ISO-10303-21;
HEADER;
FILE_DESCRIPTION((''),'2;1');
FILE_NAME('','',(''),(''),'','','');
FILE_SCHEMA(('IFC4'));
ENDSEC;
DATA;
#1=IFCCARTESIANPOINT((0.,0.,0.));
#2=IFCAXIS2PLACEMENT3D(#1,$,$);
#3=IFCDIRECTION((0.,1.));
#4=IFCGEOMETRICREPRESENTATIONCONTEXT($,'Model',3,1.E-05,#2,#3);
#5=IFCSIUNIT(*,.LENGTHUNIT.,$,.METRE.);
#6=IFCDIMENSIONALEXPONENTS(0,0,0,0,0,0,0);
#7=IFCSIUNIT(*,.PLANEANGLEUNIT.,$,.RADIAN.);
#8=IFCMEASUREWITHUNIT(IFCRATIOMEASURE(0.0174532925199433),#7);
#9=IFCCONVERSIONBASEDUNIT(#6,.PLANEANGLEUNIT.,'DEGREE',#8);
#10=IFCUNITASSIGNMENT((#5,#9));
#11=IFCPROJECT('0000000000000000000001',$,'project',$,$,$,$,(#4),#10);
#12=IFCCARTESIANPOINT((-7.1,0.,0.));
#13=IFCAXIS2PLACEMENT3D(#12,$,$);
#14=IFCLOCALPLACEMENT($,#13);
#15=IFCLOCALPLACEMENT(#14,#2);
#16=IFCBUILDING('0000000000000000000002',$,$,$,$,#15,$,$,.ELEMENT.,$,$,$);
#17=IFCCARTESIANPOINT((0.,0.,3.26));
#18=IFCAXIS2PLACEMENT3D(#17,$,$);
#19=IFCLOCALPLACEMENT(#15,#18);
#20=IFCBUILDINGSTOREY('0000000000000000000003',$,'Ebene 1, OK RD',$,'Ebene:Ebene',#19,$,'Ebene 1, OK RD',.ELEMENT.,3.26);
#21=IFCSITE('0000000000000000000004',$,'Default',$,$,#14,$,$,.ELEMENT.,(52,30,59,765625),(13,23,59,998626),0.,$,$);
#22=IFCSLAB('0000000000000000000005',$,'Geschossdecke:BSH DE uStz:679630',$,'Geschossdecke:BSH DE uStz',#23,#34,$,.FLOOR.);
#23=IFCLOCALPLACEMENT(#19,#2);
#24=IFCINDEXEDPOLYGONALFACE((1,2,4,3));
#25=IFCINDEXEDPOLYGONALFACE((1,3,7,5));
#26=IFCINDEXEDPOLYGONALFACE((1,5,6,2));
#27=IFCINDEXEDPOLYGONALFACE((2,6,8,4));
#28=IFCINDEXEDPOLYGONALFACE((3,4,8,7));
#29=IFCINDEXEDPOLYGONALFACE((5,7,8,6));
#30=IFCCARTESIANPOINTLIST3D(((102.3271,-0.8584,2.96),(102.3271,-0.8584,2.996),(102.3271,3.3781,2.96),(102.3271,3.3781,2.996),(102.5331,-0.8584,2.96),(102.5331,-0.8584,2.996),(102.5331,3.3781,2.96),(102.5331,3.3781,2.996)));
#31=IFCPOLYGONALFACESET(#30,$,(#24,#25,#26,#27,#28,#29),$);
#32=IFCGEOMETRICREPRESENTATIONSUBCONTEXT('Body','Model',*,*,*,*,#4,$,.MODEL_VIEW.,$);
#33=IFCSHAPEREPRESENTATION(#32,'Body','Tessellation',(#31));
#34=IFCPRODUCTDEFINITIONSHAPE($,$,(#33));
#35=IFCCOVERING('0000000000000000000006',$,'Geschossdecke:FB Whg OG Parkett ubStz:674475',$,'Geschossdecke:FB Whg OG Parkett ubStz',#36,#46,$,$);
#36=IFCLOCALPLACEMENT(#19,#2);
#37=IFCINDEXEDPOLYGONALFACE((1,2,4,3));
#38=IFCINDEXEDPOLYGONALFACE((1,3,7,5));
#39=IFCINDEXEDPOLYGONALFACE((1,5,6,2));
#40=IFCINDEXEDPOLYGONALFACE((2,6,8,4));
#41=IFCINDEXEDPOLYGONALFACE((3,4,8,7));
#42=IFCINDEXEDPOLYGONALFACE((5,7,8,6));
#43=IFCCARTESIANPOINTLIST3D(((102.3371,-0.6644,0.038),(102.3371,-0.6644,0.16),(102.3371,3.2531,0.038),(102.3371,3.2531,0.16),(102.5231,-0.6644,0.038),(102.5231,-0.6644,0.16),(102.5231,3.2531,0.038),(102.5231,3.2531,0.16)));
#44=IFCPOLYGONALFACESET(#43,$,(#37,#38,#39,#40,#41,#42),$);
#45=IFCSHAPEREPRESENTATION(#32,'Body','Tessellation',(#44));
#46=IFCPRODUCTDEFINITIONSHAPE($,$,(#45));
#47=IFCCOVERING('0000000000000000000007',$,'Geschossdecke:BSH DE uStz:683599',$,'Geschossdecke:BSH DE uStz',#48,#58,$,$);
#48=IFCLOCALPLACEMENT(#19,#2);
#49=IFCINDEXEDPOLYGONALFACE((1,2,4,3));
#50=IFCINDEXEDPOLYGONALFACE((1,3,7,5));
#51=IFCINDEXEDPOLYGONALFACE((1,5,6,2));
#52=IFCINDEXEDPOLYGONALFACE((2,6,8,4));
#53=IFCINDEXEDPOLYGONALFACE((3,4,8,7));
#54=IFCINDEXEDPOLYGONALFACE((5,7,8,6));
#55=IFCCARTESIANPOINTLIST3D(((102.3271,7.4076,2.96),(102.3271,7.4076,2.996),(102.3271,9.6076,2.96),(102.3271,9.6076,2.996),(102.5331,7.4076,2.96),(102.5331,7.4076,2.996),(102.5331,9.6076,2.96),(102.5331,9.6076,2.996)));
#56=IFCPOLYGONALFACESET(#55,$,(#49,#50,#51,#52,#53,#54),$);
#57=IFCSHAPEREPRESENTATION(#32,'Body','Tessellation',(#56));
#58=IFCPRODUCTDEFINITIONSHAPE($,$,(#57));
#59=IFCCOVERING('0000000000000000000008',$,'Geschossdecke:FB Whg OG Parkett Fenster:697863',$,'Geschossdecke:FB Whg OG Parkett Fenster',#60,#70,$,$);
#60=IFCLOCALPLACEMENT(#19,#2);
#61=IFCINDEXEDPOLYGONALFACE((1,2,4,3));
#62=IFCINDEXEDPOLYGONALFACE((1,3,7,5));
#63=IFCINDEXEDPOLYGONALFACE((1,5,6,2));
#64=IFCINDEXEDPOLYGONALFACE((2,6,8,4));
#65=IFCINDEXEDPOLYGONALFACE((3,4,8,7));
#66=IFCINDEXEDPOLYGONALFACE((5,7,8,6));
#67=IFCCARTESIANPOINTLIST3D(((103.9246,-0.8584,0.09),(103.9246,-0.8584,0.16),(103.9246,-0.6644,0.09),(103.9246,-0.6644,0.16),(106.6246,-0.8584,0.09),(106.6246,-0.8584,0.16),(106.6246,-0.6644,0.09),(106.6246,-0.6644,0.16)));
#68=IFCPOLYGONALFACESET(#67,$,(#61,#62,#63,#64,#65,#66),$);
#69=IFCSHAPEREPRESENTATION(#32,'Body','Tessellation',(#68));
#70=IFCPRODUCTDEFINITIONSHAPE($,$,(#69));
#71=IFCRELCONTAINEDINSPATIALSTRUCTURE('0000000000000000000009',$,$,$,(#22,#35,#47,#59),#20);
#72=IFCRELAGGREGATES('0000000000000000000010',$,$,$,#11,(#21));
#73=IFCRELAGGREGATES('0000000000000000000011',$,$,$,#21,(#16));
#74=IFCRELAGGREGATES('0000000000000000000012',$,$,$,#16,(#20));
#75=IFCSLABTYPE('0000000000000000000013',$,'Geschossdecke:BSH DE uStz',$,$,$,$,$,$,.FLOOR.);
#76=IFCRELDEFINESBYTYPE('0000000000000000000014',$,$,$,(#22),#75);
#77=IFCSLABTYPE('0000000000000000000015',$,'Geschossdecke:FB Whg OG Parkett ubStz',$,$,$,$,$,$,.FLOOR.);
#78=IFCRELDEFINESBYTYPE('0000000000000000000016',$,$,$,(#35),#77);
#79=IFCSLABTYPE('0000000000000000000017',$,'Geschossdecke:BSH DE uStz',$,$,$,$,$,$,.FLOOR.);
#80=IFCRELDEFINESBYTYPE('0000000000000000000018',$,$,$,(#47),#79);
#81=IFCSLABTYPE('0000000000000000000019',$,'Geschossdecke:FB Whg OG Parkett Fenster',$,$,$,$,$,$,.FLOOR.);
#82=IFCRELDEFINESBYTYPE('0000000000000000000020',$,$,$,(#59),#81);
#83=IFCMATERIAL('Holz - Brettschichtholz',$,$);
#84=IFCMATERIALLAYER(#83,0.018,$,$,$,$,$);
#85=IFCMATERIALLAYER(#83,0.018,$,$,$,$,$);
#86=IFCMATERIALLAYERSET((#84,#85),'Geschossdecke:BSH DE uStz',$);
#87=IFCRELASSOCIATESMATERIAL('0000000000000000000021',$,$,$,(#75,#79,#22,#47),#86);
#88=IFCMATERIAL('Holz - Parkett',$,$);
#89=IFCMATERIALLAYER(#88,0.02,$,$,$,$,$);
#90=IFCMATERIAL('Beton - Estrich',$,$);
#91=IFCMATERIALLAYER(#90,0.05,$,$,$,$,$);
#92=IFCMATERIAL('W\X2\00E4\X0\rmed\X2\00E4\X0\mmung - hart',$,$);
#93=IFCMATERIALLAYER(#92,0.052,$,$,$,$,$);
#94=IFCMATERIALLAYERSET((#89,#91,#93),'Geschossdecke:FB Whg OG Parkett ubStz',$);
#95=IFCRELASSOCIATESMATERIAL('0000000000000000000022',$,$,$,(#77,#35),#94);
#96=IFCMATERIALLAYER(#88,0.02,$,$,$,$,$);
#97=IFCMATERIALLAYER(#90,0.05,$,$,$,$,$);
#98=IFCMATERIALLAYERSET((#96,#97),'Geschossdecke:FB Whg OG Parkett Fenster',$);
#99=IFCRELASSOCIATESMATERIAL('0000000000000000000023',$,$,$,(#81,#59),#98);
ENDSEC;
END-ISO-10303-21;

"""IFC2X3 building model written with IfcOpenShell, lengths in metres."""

from ifc_helpers import new_model, entity, si_unit, converted_unit, direction, frame, frame_2d, origin, origin_2d_with_axis, place, context, subcontext, project, spatial, rectangle, extrude, material, layer, layer_set, layer_usage, type_object, element, save


model = new_model("IFC2X3")

# Units and contexts
model_context = context("Model", 3, precision=1e-05, world=origin(), true_north=direction((0.0, 1.0)))
body_context = subcontext(model_context, "Body", "Model", "MODEL_VIEW")
ifc_project = project(units=[si_unit("LENGTHUNIT", "METRE"), converted_unit("PLANEANGLEUNIT", "DEGREE", entity("IfcRatioMeasure", 0.0174532925199433), si_unit("PLANEANGLEUNIT", "RADIAN"), dimensions=[0, 0, 0, 0, 0, 0, 0])], contexts=[model_context])

# Site, building, storey
site_placement = place(None, frame((-7.1, 0.0, 0.0)))
site = spatial("IfcSite", under=ifc_project, at=site_placement, Name="Default", CompositionType="ELEMENT", RefLatitude=(52, 30, 59, 765625), RefLongitude=(13, 23, 59, 998626), RefElevation=0.0)
building_placement = place(site_placement, origin())
building = spatial("IfcBuilding", under=site, at=building_placement, CompositionType="ELEMENT")
storey_placement = place(building_placement, frame((0.0, 0.0, 3.26)))
storey = spatial("IfcBuildingStorey", under=building, at=storey_placement, Name="Ebene 1, OK RD", ObjectType="Ebene:Ebene", LongName="Ebene 1, OK RD", CompositionType="ELEMENT", Elevation=3.26)

# Slab
ifc_material_1 = material(Name="Holz - Brettschichtholz")
ifc_layer_1 = layer(ifc_material_1, 0.018)
ifc_layer_2 = layer(ifc_material_1, 0.018)
ifc_layer_set_1 = layer_set([ifc_layer_1, ifc_layer_2], Name="Geschossdecke:BSH DE uStz")
ifc_layer_usage_1 = layer_usage(ifc_layer_set_1, "AXIS3", "POSITIVE", 0.0)
slab_type_1 = type_object("IfcSlabType", Name="Geschossdecke:BSH DE uStz", PredefinedType="FLOOR", material=ifc_layer_set_1)
slab_1_placement = place(storey_placement, origin())
element("IfcSlab", 1, at=slab_1_placement, inside=storey, type_object=slab_type_1, material=ifc_layer_usage_1, Name="Geschossdecke:BSH DE uStz:679630", ObjectType="Geschossdecke:BSH DE uStz", PredefinedType="FLOOR", context=body_context, shape_type="SweptSolid", body=[
    extrude(rectangle(XDim=4.2365, YDim=0.206, at=frame_2d((0.0, 0.0), x_axis=(1.0, 0.0))), frame((102.4301, 1.2599, 2.996), z_axis=(0.0, 0.0, -1.0), x_axis=(0.0, 1.0, 0.0)), (0.0, 0.0, 1.0), 0.036),
])

# Coverings
ifc_material_2 = material(Name="Holz - Parkett")
ifc_layer_3 = layer(ifc_material_2, 0.02)
ifc_material_3 = material(Name="Beton - Estrich")
ifc_layer_4 = layer(ifc_material_3, 0.05)
ifc_material_4 = material(Name="Wärmedämmung - hart")
ifc_layer_5 = layer(ifc_material_4, 0.052)
ifc_layer_set_2 = layer_set([ifc_layer_3, ifc_layer_4, ifc_layer_5], Name="Geschossdecke:FB Whg OG Parkett ubStz")
ifc_layer_usage_2 = layer_usage(ifc_layer_set_2, "AXIS3", "POSITIVE", 0.0)
slab_type_2 = type_object("IfcSlabType", Name="Geschossdecke:FB Whg OG Parkett ubStz", PredefinedType="FLOOR", material=ifc_layer_set_2)
covering_1_placement = place(storey_placement, origin())
element("IfcCovering", 2, at=covering_1_placement, inside=storey, type_object=slab_type_2, material=ifc_layer_usage_2, Name="Geschossdecke:FB Whg OG Parkett ubStz:674475", ObjectType="Geschossdecke:FB Whg OG Parkett ubStz", context=body_context, shape_type="SweptSolid", body=[
    extrude(rectangle(XDim=3.9175, YDim=0.186, at=origin_2d_with_axis()), frame((102.4301, 1.2944, 0.16), z_axis=(0.0, 0.0, -1.0), x_axis=(0.0, 1.0, 0.0)), (0.0, 0.0, 1.0), 0.122),
])
ifc_layer_usage_3 = layer_usage(ifc_layer_set_1, "AXIS3", "POSITIVE", 0.0)
slab_type_3 = type_object("IfcSlabType", Name="Geschossdecke:BSH DE uStz", PredefinedType="FLOOR", material=ifc_layer_set_1)
covering_2_placement = place(storey_placement, origin())
element("IfcCovering", 3, at=covering_2_placement, inside=storey, type_object=slab_type_3, material=ifc_layer_usage_3, Name="Geschossdecke:BSH DE uStz:683599", ObjectType="Geschossdecke:BSH DE uStz", context=body_context, shape_type="SweptSolid", body=[
    extrude(rectangle(XDim=2.2, YDim=0.206, at=origin_2d_with_axis()), frame((102.4301, 8.5076, 2.996), z_axis=(0.0, 0.0, -1.0), x_axis=(0.0, 1.0, 0.0)), (0.0, 0.0, 1.0), 0.036),
])
ifc_layer_6 = layer(ifc_material_2, 0.02)
ifc_layer_7 = layer(ifc_material_3, 0.05)
ifc_layer_set_3 = layer_set([ifc_layer_6, ifc_layer_7], Name="Geschossdecke:FB Whg OG Parkett Fenster")
ifc_layer_usage_4 = layer_usage(ifc_layer_set_3, "AXIS3", "POSITIVE", 0.0)
slab_type_4 = type_object("IfcSlabType", Name="Geschossdecke:FB Whg OG Parkett Fenster", PredefinedType="FLOOR", material=ifc_layer_set_3)
covering_3_placement = place(storey_placement, origin())
element("IfcCovering", 4, at=covering_3_placement, inside=storey, type_object=slab_type_4, material=ifc_layer_usage_4, Name="Geschossdecke:FB Whg OG Parkett Fenster:697863", ObjectType="Geschossdecke:FB Whg OG Parkett Fenster", context=body_context, shape_type="SweptSolid", body=[
    extrude(rectangle(XDim=0.194, YDim=2.7, at=frame_2d((0.0, 0.0), x_axis=(1.0, 0.0))), frame((105.2746, -0.7614, 0.16), z_axis=(0.0, 0.0, -1.0), x_axis=(0.0, 1.0, 0.0)), (0.0, 0.0, 1.0), 0.07),
])

save(model, "model.ifc")
